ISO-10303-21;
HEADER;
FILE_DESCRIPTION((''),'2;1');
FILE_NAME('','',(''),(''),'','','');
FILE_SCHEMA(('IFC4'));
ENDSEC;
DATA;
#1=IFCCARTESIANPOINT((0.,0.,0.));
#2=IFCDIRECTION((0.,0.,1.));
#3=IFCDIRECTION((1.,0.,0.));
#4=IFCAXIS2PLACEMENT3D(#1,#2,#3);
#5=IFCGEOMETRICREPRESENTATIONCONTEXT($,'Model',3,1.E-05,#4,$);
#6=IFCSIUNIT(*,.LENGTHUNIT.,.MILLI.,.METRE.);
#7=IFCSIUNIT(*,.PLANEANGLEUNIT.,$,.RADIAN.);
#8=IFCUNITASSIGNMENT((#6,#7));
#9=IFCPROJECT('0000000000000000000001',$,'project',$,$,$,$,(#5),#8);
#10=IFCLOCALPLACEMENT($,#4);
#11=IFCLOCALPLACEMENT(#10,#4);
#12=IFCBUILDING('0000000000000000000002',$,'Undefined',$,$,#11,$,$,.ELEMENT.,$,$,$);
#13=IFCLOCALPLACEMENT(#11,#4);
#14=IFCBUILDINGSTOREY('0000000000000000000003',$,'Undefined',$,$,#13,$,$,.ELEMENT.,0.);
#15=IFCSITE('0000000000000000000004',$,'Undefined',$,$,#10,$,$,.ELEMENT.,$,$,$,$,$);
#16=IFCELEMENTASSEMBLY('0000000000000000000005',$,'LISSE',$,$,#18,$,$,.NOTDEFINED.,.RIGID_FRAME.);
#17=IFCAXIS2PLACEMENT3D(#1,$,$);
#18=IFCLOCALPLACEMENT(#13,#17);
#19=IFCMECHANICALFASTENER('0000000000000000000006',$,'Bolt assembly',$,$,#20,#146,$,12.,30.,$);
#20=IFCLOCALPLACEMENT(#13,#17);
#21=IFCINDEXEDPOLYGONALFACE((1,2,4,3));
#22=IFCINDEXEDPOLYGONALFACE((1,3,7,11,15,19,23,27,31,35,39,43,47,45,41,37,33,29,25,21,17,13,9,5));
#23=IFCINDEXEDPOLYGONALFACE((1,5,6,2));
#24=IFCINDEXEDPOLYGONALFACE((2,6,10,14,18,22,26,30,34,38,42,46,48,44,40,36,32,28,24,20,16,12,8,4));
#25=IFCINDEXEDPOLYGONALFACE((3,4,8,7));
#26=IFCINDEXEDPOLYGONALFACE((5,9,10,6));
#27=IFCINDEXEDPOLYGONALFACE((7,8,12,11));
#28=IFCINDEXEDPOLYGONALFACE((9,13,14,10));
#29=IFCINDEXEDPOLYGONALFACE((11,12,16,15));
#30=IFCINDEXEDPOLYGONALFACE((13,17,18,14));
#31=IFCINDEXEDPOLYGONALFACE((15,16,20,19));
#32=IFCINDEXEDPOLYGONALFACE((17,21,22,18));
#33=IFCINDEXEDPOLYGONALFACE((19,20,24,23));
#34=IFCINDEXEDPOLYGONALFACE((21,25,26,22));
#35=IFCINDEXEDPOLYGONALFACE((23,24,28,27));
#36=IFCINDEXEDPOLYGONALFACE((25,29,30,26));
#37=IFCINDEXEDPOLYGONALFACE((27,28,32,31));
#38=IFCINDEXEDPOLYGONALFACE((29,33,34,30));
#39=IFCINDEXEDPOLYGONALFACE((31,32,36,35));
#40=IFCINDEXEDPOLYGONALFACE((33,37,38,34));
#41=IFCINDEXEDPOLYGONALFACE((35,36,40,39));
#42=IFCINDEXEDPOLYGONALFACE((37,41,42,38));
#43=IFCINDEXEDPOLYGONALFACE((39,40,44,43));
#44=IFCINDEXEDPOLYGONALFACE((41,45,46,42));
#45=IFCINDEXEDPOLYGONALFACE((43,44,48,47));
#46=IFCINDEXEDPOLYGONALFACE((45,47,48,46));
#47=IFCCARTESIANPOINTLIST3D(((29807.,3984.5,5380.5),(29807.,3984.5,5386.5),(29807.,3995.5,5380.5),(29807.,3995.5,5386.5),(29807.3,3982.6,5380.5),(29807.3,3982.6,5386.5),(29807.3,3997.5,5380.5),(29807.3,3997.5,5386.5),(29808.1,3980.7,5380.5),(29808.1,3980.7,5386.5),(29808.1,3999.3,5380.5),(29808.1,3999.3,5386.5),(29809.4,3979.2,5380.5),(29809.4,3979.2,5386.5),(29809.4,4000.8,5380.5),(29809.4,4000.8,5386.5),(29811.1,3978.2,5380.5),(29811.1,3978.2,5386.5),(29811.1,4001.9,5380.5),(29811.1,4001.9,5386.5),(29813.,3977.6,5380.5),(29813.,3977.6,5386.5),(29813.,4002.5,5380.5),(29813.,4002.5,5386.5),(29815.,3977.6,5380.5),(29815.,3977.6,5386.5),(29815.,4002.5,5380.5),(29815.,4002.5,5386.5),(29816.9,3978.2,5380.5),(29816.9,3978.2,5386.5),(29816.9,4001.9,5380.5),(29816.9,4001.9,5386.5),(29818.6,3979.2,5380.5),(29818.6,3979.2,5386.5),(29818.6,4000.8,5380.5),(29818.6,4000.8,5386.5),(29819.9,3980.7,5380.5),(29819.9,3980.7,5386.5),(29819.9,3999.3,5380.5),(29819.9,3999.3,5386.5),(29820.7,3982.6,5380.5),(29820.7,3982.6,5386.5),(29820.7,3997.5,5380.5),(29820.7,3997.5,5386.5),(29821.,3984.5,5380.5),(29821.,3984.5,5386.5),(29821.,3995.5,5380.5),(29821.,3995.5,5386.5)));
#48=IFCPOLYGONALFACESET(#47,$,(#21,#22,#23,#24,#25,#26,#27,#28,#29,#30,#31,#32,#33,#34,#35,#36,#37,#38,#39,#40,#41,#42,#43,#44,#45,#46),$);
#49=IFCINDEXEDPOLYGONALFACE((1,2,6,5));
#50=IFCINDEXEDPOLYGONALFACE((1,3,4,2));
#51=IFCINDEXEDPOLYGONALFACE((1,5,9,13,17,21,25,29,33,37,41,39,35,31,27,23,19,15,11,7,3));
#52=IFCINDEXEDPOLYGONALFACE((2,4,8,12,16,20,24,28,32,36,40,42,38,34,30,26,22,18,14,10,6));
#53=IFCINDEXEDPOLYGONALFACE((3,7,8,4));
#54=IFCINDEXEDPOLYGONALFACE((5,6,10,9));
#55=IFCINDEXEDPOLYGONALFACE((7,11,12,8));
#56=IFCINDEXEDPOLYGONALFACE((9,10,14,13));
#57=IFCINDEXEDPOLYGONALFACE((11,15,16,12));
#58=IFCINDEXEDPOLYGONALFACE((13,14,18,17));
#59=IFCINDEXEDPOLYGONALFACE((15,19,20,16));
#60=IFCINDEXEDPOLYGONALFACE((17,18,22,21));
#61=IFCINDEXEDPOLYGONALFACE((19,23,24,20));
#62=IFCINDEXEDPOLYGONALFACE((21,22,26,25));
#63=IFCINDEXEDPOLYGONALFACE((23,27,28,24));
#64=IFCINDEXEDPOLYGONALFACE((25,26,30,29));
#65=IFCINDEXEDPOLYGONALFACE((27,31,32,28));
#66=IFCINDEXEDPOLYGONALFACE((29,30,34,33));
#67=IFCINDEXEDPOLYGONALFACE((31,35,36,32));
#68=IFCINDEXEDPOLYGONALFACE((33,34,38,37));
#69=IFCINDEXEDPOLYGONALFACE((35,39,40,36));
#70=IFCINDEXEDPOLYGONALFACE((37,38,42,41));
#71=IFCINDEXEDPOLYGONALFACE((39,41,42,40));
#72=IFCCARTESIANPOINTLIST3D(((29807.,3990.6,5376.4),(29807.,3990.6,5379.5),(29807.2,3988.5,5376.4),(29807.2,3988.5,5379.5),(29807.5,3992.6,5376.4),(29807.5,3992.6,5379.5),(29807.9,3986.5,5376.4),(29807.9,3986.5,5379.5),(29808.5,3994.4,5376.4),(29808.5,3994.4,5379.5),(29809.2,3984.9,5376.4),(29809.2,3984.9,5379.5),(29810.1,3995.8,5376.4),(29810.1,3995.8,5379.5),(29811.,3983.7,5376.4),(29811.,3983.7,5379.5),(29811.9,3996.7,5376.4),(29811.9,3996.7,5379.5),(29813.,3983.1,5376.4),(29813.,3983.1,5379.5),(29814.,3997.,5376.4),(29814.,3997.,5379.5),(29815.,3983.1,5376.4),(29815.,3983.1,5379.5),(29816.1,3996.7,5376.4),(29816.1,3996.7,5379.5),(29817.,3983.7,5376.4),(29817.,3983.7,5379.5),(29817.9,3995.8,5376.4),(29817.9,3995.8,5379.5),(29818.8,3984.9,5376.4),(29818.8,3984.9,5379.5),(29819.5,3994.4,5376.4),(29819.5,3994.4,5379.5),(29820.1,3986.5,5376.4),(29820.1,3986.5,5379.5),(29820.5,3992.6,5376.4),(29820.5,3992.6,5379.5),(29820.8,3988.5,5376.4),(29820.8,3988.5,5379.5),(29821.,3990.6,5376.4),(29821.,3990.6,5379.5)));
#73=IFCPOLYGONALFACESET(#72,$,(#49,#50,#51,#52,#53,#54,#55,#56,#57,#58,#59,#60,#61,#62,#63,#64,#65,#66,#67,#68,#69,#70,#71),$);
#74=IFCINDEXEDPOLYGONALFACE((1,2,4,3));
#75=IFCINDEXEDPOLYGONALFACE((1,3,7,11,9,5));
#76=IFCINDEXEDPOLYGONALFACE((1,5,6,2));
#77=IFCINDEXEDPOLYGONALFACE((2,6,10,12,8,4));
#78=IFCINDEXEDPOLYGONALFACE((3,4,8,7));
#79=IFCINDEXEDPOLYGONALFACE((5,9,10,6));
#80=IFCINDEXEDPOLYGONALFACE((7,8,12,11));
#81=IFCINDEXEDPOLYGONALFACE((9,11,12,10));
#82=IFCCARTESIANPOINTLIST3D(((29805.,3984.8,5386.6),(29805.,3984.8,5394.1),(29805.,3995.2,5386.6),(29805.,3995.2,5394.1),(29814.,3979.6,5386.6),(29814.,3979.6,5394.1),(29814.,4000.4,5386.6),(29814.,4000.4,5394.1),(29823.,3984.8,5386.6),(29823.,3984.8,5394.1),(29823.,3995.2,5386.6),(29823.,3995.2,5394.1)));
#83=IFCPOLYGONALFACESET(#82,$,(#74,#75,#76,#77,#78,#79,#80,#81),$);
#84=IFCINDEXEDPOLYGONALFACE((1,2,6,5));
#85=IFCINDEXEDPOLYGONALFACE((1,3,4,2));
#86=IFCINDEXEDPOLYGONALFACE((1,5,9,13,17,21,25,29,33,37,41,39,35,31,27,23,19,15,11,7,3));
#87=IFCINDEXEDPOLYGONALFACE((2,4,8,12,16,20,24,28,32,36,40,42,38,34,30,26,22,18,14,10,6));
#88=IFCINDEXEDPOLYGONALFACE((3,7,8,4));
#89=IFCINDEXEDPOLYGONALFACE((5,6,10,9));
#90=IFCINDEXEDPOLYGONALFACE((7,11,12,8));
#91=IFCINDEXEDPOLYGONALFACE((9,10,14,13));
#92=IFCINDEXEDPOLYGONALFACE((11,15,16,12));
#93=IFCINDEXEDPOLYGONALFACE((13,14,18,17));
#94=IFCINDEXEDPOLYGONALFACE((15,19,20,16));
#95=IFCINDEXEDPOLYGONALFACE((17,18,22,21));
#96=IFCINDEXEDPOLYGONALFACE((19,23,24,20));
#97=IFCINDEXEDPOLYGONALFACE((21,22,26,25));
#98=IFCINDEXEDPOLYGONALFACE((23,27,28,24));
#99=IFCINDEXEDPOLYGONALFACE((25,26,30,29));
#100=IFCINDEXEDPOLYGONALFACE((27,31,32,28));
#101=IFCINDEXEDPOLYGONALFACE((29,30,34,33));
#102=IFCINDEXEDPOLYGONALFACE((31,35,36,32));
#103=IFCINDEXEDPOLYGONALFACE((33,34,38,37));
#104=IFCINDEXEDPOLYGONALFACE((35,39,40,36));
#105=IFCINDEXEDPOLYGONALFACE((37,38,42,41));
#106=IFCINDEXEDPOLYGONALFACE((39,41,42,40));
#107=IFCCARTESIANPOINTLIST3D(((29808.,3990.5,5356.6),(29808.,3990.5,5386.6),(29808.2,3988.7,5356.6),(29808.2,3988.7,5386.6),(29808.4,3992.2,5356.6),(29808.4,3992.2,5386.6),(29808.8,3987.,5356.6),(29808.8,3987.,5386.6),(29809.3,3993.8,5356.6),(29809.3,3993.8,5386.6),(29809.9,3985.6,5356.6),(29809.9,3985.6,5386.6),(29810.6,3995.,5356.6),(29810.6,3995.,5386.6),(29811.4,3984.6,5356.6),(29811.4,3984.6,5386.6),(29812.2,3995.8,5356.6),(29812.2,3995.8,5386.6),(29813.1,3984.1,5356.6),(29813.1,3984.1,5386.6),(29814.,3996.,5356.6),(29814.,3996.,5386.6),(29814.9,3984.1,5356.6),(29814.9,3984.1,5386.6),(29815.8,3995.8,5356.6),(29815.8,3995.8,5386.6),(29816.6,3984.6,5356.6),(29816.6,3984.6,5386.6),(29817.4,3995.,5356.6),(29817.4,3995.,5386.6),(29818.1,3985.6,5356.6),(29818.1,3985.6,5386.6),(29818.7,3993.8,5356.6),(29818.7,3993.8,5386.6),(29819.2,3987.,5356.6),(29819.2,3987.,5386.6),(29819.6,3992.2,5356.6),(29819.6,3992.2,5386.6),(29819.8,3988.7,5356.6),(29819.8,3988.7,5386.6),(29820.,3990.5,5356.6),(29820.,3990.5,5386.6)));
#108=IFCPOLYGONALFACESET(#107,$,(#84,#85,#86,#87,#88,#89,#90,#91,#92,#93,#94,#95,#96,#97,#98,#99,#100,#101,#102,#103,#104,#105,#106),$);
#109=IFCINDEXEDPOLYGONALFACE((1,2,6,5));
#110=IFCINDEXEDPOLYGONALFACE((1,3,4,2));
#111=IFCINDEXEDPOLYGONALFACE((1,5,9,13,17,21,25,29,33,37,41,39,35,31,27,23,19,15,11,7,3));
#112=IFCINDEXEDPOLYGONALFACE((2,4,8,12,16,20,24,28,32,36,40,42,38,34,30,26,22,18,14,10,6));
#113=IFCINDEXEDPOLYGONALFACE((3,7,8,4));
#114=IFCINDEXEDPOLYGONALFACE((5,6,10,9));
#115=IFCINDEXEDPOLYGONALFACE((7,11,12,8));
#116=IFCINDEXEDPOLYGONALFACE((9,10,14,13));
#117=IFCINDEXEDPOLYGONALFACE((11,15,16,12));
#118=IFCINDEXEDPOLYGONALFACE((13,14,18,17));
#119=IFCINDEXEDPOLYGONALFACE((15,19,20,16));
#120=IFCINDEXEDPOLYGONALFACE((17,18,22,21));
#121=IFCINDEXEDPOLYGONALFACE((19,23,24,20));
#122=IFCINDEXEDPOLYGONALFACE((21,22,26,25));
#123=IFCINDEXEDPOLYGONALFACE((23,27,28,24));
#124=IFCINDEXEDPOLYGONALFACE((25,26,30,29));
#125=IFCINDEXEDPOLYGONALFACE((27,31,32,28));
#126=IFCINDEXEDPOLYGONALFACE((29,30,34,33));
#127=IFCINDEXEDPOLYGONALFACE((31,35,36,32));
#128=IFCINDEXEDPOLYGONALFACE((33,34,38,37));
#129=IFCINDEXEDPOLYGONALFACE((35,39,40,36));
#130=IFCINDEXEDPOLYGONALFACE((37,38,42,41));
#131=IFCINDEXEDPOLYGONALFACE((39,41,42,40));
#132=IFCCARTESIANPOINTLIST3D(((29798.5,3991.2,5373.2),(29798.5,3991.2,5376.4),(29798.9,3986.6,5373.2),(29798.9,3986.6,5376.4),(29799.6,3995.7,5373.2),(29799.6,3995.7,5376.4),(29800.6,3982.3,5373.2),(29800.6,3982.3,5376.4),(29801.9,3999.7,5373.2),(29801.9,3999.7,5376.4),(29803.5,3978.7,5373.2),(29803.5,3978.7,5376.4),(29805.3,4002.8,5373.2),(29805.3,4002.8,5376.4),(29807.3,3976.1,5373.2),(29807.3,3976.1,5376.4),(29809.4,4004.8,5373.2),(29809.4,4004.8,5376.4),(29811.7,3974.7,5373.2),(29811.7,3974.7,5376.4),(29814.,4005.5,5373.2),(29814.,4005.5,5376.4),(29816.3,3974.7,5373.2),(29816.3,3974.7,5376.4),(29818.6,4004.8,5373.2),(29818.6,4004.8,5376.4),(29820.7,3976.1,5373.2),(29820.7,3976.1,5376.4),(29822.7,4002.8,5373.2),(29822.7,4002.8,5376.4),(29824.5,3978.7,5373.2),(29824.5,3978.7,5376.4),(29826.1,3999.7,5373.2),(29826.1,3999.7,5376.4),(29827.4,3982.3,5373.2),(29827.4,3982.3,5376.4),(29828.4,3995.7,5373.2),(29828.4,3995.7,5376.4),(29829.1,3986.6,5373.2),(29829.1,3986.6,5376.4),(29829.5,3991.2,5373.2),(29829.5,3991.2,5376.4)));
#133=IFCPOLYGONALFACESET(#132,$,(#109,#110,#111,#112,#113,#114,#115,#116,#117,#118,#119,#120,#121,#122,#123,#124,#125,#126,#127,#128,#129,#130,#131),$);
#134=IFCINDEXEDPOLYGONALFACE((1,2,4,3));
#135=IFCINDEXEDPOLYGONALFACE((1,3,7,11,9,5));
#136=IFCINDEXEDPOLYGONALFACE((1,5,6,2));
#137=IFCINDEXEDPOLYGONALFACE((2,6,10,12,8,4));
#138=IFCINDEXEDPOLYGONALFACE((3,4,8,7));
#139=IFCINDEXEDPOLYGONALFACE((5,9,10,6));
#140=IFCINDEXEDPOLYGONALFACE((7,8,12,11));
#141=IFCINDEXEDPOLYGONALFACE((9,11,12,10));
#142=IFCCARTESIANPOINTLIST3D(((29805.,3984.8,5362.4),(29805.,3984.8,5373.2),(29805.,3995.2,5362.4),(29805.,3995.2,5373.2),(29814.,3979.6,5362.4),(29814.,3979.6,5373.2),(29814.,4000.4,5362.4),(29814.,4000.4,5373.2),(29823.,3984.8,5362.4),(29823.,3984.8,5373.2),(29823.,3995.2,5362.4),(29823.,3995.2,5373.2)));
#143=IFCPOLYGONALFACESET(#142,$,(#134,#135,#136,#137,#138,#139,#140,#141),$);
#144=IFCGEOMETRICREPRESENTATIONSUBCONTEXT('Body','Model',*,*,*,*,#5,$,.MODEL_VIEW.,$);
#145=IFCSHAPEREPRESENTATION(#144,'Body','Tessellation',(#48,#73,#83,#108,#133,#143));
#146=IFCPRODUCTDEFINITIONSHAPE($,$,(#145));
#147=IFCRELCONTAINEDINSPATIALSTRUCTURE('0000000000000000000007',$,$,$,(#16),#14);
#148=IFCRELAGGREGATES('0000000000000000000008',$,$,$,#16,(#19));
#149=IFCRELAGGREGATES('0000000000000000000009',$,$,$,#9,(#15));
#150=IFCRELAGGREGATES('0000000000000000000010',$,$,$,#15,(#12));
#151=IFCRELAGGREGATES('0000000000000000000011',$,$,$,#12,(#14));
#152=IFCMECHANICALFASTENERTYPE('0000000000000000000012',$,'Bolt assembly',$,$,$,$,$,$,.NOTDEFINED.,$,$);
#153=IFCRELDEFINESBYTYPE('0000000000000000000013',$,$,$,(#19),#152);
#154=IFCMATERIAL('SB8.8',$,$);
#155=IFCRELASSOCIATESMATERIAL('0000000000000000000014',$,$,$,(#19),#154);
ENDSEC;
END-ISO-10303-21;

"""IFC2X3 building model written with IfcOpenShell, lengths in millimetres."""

from ifc_helpers import new_model, si_unit, frame, frame_2d, origin_with_axes, origin_2d_with_axis, place, context, subcontext, project, spatial, polyline, circle_curve, parameter, trimmed, segment, composite_curve, circle, outline, extrude, source, transform, mapped, material, type_object, element, aggregate, save


model = new_model("IFC2X3")

# Units and contexts
model_context = context("Model", 3, precision=1e-05, world=origin_with_axes())
body_context = subcontext(model_context, "Body", "Model", "MODEL_VIEW")
ifc_project = project(units=[si_unit("LENGTHUNIT", "METRE", prefix="MILLI"), si_unit("PLANEANGLEUNIT", "RADIAN")], contexts=[model_context])

# Site, building, storey
site_placement = place(None, origin_with_axes())
site = spatial("IfcSite", under=ifc_project, at=site_placement, Name="Undefined", CompositionType="ELEMENT")
building_placement = place(site_placement, origin_with_axes())
building = spatial("IfcBuilding", under=site, at=building_placement, Name="Undefined", CompositionType="ELEMENT")
storey_placement = place(building_placement, origin_with_axes())
storey = spatial("IfcBuildingStorey", under=building, at=storey_placement, Name="Undefined", CompositionType="ELEMENT", Elevation=0.0)

# Element assembly
assembly_1_placement = place(storey_placement, origin_with_axes())
assembly_1 = element("IfcElementAssembly", 1, at=assembly_1_placement, inside=storey, Name="LISSE", AssemblyPlace="NOTDEFINED", PredefinedType="RIGID_FRAME")

# Shared definitions
ifc_material_1 = material(Name="SB8.8")
mechanical_fastener_type = type_object("IfcMechanicalFastenerType", Name="Bolt assembly")

# Mechanical fastener
shared_shape_1 = source(origin_with_axes(), body_context, "Body", "SweptSolid", [
    extrude(outline(composite_curve([segment(polyline([(-5.5, 7.0), (5.5, 7.0)]), True, "CONTINUOUS"), segment(trimmed(circle_curve(frame_2d((5.5, 0.0), x_axis=(0.0, 1.0)), 7.0), [parameter(0.0)], [parameter(3.141593)], False, "PARAMETER"), True, "CONTINUOUS"), segment(polyline([(5.5, -7.0), (-5.5, -7.0)]), True, "CONTINUOUS"), segment(trimmed(circle_curve(frame_2d((-5.5, 0.0), x_axis=(0.0, -1.0)), 7.0), [parameter(0.0)], [parameter(3.141593)], False, "PARAMETER"), True, "DISCONTINUOUS")], self_intersect=False)), frame((0.0, -5.9, 0.0), z_axis=(0.0, 1.0, 0.0), x_axis=(1.0, 0.0, 0.0)), (0.0, 0.0, 1.0), 6.0),
    extrude(circle(Radius=7.0, at=origin_2d_with_axis()), frame((0.0, 1.1, 0.0), z_axis=(0.0, 1.0, 0.0), x_axis=(1.0, 0.0, 0.0)), (0.0, 0.0, 1.0), 3.1),
    extrude(outline(polyline([(10.4, 0.0), (5.2, 9.0), (-5.2, 9.0), (-10.4, 0.0), (-5.2, -9.0), (5.2, -9.0), (10.4, 0.0)])), frame((0.0, -13.5, 0.0), z_axis=(0.0, 1.0, 0.0), x_axis=(1.0, 0.0, 0.0)), (0.0, 0.0, 1.0), 7.5),
    extrude(circle(Radius=6.0, at=origin_2d_with_axis()), frame((0.0, -6.0, 0.0), z_axis=(0.0, 1.0, 0.0), x_axis=(1.0, 0.0, 0.0)), (0.0, 0.0, 1.0), 30.0),
    extrude(circle(Radius=15.5, at=origin_2d_with_axis()), frame((0.0, 4.2, 0.0), z_axis=(0.0, 1.0, 0.0), x_axis=(1.0, 0.0, 0.0)), (0.0, 0.0, 1.0), 3.2),
    extrude(outline(polyline([(10.4, 0.0), (5.2, 9.0), (-5.2, 9.0), (-10.4, 0.0), (-5.2, -9.0), (5.2, -9.0), (10.4, 0.0)])), frame((0.0, 7.4, 0.0), z_axis=(0.0, 1.0, 0.0), x_axis=(1.0, 0.0, 0.0)), (0.0, 0.0, 1.0), 10.8),
])
mechanical_fastener_1_placement = place(assembly_1_placement, frame((29814.0, 3990.0, 5380.6), z_axis=(-1.0, 0.0, 0.0), x_axis=(0.0, 1.0, 0.0)))
mechanical_fastener_1 = element("IfcMechanicalFastener", 2, at=mechanical_fastener_1_placement, type_object=mechanical_fastener_type, material=ifc_material_1, Name="Bolt assembly", NominalDiameter=12.0, NominalLength=30.0, context=body_context, shape_type="MappedRepresentation", body=[
    mapped(shared_shape_1, transform((0.0, 0.0, 0.0))),
])
aggregate(assembly_1, [mechanical_fastener_1])

save(model, "model.ifc")
